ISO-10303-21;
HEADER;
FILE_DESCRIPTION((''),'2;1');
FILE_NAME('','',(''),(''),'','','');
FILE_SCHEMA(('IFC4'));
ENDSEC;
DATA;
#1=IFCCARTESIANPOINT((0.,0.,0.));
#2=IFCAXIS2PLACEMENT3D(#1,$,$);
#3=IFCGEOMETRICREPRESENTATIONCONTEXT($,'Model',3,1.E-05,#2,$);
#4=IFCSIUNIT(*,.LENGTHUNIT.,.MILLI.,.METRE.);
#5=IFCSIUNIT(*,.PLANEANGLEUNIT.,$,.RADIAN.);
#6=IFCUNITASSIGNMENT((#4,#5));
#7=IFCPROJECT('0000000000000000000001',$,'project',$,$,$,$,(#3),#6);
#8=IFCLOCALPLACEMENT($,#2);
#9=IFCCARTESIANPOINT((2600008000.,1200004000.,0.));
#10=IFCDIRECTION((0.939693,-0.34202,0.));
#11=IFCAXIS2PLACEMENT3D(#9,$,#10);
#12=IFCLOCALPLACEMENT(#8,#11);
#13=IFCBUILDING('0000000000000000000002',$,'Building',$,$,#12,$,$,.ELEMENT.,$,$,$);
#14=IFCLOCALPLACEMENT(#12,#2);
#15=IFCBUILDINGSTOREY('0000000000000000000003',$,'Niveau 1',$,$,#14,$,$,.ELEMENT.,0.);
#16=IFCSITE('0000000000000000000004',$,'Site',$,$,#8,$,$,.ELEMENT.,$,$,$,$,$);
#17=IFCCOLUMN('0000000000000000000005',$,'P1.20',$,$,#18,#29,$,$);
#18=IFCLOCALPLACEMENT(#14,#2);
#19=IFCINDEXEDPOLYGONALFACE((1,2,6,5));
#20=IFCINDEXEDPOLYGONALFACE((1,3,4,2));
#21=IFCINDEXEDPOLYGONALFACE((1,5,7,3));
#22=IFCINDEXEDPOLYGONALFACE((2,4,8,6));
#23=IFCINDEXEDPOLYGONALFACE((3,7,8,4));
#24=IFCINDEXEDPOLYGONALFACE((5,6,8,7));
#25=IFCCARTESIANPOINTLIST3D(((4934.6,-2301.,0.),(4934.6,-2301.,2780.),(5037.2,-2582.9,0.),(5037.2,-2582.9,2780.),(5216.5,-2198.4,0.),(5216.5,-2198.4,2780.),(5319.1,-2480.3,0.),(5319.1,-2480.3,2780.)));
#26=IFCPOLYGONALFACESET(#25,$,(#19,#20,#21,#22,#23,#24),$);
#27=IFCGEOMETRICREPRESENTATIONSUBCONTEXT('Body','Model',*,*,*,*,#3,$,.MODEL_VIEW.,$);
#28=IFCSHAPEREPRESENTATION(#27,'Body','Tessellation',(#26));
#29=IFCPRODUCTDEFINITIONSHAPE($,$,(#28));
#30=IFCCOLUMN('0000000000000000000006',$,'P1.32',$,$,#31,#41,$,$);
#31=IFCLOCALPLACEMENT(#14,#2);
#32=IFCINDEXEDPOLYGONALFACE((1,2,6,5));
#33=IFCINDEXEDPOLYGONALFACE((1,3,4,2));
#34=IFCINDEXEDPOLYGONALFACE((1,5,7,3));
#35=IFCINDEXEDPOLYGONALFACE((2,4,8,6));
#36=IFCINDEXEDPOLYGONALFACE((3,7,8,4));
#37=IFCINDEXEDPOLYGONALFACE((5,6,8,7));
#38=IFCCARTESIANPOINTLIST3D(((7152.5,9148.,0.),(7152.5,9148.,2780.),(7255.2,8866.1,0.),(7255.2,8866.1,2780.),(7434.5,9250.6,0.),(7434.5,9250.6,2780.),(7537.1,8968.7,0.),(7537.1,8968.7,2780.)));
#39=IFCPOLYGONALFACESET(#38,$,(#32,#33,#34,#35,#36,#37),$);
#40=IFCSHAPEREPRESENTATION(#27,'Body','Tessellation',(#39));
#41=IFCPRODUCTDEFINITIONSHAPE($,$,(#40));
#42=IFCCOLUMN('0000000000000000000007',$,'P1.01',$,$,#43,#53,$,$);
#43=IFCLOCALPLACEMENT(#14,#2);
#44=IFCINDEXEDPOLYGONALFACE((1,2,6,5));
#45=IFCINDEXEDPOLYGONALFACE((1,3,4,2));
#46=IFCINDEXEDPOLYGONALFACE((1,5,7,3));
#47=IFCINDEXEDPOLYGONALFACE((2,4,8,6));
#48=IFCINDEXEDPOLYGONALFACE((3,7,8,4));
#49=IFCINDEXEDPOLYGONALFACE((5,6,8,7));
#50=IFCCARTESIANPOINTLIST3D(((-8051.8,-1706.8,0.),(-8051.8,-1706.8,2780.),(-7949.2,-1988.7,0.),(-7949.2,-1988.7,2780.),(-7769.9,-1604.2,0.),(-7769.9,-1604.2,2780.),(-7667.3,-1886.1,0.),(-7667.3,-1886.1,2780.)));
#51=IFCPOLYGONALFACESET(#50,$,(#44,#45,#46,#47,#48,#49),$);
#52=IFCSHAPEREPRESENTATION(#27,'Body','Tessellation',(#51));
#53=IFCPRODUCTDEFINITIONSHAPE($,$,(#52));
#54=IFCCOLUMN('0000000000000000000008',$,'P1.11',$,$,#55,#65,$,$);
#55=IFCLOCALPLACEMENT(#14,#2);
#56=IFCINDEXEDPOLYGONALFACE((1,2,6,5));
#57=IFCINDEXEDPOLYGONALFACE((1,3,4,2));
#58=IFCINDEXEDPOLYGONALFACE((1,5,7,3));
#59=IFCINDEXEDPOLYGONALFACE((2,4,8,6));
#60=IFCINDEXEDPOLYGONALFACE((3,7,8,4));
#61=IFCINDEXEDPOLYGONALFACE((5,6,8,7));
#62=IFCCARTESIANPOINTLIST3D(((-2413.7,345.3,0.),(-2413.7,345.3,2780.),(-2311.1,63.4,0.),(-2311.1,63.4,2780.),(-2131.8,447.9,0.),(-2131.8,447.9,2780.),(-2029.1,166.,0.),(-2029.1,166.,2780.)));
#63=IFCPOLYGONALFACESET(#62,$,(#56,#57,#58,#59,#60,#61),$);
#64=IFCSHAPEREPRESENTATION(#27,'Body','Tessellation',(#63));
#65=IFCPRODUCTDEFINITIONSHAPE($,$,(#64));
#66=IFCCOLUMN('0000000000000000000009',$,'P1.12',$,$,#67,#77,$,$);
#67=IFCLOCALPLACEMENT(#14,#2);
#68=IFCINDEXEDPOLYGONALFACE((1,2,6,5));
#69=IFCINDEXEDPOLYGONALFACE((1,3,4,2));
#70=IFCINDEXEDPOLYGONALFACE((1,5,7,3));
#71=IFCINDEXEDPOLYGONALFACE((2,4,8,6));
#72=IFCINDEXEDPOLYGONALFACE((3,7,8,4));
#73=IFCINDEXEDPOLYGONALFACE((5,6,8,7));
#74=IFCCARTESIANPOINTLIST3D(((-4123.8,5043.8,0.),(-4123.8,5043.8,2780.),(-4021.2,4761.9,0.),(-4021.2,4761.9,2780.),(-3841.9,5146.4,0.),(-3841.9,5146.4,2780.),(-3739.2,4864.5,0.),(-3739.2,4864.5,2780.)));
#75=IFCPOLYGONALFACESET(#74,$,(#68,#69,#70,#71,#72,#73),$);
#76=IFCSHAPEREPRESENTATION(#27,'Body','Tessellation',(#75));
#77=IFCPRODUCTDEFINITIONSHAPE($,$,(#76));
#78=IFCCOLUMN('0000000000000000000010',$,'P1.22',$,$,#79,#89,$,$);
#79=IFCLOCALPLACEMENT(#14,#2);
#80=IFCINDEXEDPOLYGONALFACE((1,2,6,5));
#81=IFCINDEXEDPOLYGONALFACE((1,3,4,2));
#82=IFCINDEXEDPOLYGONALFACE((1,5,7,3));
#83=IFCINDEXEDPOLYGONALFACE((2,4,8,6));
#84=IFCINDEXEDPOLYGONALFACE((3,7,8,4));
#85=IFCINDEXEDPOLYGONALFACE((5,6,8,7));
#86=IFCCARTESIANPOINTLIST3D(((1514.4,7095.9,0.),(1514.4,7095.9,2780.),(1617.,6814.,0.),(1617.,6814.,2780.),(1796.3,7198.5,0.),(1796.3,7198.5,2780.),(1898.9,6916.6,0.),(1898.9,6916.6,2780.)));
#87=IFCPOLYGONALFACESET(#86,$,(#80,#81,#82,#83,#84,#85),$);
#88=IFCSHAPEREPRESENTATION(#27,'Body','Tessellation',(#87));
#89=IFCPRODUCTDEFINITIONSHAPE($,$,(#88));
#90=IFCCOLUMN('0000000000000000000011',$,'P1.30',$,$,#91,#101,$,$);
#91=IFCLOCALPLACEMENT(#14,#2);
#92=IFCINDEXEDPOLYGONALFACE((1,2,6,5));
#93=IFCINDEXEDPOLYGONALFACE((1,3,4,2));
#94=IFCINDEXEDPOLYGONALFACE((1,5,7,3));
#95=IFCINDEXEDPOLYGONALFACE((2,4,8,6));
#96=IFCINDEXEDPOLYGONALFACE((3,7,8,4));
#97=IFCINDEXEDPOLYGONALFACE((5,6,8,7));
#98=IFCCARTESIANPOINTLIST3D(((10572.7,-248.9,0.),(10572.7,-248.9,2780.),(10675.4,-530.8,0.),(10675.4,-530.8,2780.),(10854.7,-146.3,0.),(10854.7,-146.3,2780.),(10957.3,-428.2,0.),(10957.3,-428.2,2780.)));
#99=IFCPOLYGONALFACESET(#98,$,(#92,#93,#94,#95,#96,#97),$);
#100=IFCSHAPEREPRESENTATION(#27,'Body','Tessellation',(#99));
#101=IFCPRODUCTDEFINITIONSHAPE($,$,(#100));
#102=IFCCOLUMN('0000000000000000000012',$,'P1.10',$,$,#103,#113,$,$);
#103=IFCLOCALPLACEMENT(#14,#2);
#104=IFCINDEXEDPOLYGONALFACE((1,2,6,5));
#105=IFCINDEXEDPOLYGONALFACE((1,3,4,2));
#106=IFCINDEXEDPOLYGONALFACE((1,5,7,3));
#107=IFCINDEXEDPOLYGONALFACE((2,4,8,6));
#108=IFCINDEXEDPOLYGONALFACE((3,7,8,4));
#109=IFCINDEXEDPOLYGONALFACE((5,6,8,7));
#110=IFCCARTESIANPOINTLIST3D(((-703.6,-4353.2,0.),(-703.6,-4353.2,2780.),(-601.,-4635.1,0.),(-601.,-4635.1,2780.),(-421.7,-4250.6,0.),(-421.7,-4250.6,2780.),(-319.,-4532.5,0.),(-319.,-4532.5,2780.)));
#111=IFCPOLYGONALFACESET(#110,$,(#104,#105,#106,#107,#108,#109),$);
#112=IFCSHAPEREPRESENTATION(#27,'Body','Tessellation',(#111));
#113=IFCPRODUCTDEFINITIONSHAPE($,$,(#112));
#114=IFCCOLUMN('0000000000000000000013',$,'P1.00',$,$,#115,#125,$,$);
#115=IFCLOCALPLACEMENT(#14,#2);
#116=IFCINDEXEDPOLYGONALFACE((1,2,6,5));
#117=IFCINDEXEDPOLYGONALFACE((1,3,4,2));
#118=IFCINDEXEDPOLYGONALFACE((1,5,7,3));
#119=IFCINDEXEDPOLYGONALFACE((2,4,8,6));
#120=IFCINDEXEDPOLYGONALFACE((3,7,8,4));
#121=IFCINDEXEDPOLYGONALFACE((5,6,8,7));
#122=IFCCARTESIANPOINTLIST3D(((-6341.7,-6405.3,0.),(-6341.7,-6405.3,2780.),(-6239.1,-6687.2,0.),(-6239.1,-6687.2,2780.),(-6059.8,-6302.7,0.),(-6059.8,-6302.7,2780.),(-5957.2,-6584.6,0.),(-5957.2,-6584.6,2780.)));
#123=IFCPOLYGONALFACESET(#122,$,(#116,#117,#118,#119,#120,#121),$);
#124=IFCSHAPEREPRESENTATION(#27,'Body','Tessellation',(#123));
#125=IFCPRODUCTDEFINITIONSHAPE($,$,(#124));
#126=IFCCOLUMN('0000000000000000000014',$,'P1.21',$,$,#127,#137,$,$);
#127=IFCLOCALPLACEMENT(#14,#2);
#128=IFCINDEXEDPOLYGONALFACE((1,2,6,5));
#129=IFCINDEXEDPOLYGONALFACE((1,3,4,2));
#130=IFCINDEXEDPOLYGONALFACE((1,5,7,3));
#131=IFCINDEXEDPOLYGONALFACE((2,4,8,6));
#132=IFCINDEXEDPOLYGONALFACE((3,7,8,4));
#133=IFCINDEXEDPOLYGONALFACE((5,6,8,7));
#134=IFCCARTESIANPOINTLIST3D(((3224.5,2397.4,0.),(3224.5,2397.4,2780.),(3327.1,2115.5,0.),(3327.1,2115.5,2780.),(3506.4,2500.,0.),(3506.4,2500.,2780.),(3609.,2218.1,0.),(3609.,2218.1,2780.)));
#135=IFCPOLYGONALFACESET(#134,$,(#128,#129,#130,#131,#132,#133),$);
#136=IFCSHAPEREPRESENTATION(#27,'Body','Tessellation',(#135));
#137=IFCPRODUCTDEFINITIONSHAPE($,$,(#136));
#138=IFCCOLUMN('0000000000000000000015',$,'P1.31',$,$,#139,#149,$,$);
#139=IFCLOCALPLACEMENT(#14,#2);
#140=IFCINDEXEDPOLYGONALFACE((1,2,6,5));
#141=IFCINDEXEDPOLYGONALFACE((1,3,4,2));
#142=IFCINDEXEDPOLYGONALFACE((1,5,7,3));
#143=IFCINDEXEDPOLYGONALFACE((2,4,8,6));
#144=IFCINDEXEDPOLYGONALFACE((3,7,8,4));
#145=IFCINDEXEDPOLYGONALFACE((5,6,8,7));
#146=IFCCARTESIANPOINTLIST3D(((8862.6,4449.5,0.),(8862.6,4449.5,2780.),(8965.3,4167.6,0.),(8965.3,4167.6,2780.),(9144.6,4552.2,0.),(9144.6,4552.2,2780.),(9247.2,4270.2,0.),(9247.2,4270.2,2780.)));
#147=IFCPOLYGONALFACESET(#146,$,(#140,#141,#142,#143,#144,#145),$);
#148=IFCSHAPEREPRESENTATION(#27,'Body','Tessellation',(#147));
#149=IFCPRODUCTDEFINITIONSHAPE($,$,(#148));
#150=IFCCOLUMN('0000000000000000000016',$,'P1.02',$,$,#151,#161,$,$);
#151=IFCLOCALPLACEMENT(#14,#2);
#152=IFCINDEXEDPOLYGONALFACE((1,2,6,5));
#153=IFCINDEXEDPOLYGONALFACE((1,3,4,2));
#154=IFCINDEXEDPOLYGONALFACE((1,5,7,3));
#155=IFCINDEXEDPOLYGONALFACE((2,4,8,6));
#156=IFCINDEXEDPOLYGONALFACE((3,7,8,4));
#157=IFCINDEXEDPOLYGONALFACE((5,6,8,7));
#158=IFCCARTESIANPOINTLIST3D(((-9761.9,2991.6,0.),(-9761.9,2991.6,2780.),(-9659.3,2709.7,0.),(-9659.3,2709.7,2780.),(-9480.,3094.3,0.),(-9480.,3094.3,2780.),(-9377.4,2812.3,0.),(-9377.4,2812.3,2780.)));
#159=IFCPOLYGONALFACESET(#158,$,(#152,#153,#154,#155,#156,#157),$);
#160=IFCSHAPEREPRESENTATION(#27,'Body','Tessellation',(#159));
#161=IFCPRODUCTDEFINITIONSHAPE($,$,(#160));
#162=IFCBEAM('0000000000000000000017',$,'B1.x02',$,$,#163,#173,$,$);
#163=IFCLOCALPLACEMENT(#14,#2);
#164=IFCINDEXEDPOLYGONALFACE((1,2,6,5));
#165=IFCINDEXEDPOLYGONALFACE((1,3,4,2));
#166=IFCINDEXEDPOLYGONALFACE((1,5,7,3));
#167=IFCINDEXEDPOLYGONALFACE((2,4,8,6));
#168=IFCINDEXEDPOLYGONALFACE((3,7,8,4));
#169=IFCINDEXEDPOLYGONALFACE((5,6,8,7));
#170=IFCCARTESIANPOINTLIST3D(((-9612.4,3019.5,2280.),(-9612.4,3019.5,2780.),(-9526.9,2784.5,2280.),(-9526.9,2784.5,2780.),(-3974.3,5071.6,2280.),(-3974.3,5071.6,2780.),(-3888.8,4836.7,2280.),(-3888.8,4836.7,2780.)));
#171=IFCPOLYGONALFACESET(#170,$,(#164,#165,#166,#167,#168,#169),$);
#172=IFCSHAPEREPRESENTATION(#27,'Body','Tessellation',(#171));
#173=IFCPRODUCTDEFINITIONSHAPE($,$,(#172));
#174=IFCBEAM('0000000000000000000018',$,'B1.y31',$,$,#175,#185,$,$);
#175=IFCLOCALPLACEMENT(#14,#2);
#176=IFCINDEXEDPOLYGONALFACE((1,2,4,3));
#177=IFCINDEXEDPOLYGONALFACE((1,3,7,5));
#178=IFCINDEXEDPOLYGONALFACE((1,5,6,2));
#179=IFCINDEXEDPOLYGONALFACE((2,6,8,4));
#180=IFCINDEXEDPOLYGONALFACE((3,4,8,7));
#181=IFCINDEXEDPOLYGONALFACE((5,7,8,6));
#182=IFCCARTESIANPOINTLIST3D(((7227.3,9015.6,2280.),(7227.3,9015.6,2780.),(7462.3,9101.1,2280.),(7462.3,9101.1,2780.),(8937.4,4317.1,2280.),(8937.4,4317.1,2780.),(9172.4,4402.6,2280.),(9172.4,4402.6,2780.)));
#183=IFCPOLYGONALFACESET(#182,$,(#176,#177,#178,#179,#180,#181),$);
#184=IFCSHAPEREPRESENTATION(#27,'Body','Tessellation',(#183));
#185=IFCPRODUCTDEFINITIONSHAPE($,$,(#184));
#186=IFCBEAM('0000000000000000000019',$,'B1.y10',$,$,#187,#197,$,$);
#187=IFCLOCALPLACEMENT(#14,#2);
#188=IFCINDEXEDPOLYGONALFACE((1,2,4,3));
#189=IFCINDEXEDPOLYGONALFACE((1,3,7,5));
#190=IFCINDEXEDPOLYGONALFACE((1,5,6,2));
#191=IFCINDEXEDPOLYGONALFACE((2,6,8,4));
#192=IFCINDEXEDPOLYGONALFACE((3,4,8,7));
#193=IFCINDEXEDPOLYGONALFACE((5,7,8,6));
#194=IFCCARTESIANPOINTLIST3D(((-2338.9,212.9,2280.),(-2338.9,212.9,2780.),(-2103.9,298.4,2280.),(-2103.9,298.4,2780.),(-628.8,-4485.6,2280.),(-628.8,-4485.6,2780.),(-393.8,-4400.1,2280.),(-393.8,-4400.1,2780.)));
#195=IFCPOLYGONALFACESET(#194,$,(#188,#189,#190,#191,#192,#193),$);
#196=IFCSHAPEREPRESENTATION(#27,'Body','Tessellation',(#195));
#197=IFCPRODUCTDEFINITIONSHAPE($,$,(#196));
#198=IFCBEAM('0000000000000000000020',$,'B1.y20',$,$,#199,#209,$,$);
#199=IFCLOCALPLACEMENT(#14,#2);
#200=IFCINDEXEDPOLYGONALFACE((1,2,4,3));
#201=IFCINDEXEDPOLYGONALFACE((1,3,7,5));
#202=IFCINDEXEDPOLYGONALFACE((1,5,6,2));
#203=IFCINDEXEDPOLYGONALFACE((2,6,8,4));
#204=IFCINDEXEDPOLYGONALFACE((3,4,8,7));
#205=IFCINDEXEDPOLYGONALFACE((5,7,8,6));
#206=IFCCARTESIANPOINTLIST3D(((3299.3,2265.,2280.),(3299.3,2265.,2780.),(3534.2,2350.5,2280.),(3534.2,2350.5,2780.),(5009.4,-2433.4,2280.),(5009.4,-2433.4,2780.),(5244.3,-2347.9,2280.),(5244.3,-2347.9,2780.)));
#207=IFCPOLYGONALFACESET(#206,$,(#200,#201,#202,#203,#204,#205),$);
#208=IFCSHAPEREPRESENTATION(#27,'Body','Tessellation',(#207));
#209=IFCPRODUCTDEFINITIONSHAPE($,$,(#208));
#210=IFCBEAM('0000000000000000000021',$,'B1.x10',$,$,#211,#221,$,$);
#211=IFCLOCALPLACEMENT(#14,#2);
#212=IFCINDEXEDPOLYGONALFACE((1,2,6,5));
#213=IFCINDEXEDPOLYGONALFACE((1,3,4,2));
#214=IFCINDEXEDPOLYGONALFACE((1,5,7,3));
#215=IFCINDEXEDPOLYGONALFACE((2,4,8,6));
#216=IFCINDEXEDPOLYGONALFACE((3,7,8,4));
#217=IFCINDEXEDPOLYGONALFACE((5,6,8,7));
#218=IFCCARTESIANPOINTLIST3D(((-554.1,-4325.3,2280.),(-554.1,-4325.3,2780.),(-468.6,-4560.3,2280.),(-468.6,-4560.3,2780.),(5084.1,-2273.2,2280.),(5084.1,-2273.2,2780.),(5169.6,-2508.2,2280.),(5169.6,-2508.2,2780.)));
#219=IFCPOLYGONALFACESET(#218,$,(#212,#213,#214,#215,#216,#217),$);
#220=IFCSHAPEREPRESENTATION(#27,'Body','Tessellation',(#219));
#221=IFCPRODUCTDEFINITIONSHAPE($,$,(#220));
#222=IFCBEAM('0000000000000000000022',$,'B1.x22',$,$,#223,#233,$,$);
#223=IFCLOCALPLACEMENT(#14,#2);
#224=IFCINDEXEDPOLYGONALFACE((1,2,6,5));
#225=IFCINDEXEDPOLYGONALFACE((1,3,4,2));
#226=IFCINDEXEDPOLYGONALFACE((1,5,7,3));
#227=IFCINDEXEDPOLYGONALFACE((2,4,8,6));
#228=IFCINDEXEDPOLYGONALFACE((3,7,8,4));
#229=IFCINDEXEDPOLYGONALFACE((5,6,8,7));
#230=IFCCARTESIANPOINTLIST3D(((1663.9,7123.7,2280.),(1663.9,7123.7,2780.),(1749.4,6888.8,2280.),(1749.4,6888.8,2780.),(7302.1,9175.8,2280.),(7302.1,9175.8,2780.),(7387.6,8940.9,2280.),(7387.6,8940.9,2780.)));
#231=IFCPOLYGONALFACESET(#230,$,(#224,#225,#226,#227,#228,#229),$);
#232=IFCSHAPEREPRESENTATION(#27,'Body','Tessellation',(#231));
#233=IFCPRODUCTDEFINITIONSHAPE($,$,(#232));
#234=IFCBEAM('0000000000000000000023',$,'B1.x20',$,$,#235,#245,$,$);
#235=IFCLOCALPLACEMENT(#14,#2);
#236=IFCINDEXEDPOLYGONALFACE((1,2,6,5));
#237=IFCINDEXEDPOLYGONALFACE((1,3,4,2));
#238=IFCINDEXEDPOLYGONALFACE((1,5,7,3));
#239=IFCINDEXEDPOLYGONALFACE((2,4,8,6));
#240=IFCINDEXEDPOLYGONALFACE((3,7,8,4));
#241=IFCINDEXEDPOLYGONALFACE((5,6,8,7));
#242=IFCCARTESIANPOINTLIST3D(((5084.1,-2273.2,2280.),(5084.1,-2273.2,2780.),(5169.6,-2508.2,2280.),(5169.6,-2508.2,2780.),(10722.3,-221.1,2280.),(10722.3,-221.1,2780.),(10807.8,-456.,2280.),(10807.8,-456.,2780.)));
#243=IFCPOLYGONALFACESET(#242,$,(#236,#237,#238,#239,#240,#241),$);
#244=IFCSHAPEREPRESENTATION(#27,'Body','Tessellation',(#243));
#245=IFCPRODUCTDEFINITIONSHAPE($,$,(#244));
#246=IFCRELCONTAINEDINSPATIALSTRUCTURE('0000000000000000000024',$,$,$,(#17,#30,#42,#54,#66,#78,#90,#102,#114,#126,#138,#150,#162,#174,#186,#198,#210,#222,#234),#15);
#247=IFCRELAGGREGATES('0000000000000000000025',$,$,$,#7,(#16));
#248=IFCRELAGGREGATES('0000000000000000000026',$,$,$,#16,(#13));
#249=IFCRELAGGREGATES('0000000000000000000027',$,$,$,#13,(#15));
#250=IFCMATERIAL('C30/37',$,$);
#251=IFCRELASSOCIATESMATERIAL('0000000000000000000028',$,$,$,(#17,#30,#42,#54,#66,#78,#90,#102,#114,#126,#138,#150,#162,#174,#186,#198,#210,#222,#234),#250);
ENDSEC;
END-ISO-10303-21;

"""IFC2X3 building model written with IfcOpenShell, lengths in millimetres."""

from ifc_helpers import new_model, si_unit, frame, origin, origin_2d, place, context, subcontext, project, spatial, rectangle, extrude, material, element, save


model = new_model("IFC2X3")

# Units and contexts
model_context = context("Model", 3, precision=1e-05, world=origin())
body_context = subcontext(model_context, "Body", "Model", "MODEL_VIEW")
ifc_project = project(units=[si_unit("LENGTHUNIT", "METRE", prefix="MILLI"), si_unit("PLANEANGLEUNIT", "RADIAN")], contexts=[model_context])

# Site, building, storey
site_placement = place(None, origin())
site = spatial("IfcSite", under=ifc_project, at=site_placement, Name="Site", CompositionType="ELEMENT")
building_placement = place(site_placement, frame((2600008000.0, 1200004000.0, 0.0), x_axis=(0.939693, -0.34202, 0.0)))
building = spatial("IfcBuilding", under=site, at=building_placement, Name="Building", CompositionType="ELEMENT")
storey_placement = place(building_placement, origin())
storey = spatial("IfcBuildingStorey", under=building, at=storey_placement, Name="Niveau 1", CompositionType="ELEMENT", Elevation=0.0)

# Columns
ifc_material = material(Name="C30/37")
for number, where, z_axis, x_axis, name in (
    (1, (5126.9, -2390.7, 0.0), (0.0, 0.0, 1.0), (0.939693, 0.34202, 0.0), "P1.20"),
    (2, (7344.8, 9058.4, 0.0), (0.0, 0.0, 1.0), (0.939693, 0.34202, 0.0), "P1.32"),
    (3, (-7859.6, -1796.5, 0.0), (0.0, 0.0, 1.0), (0.939693, 0.34202, 0.0), "P1.01"),
    (4, (-2221.4, 255.7, 0.0), (0.0, 0.0, 1.0), (0.939693, 0.34202, 0.0), "P1.11"),
    (5, (-3931.5, 4954.1, 0.0), (0.0, 0.0, 1.0), (0.939693, 0.34202, 0.0), "P1.12"),
    (6, (1706.6, 7006.2, 0.0), (0.0, 0.0, 1.0), (0.939693, 0.34202, 0.0), "P1.22"),
    (7, (10765.0, -338.6, 0.0), (0.0, 0.0, 1.0), (0.939693, 0.34202, 0.0), "P1.30"),
    (8, (-511.3, -4442.8, 0.0), (0.0, 0.0, 1.0), (0.939693, 0.34202, 0.0), "P1.10"),
    (9, (-6149.5, -6494.9, 0.0), (0.0, 0.0, 1.0), (0.939693, 0.34202, 0.0), "P1.00"),
    (10, (3416.8, 2307.8, 0.0), (0.0, 0.0, 1.0), (0.939693, 0.34202, 0.0), "P1.21"),
    (11, (9054.9, 4359.9, 0.0), (0.0, 0.0, 1.0), (0.939693, 0.34202, 0.0), "P1.31"),
    (12, (-9569.7, 2902.0, 0.0), (0.0, 0.0, 1.0), (0.939693, 0.34202, 0.0), "P1.02"),
):
    element("IfcColumn", number, at=place(storey_placement, frame(where, z_axis=z_axis, x_axis=x_axis)), inside=storey, material=ifc_material, Name=name, context=body_context, shape_type="SweptSolid", body=[
        extrude(rectangle(XDim=300.0, YDim=300.0, at=origin_2d()), origin(), (0.0, 0.0, 1.0), 2780.0),
    ])

# Beams
beam_1_placement = place(storey_placement, frame((-9569.7, 2902.0, 2530.0), z_axis=(0.939693, 0.34202, 0.0), x_axis=(-0.34202, 0.939693, 0.0)))
element("IfcBeam", 13, at=beam_1_placement, inside=storey, material=ifc_material, Name="B1.x02", context=body_context, shape_type="SweptSolid", body=[
    extrude(rectangle(XDim=250.0, YDim=500.0, at=origin_2d()), origin(), (0.0, 0.0, 1.0), 6000.0),
])
for number, where, z_axis, x_axis, name in (
    (14, (9054.9, 4359.9, 2530.0), (-0.34202, 0.939693, 0.0), (-0.939693, -0.34202, 0.0), "B1.y31"),
    (15, (-511.3, -4442.8, 2530.0), (-0.34202, 0.939693, 0.0), (-0.939693, -0.34202, 0.0), "B1.y10"),
    (16, (5126.9, -2390.7, 2530.0), (-0.34202, 0.939693, 0.0), (-0.939693, -0.34202, 0.0), "B1.y20"),
):
    element("IfcBeam", number, at=place(storey_placement, frame(where, z_axis=z_axis, x_axis=x_axis)), inside=storey, material=ifc_material, Name=name, context=body_context, shape_type="SweptSolid", body=[
        extrude(rectangle(XDim=250.0, YDim=500.0, at=origin_2d()), origin(), (0.0, 0.0, 1.0), 5000.0),
    ])
for number, where, z_axis, x_axis, name in (
    (17, (-511.3, -4442.8, 2530.0), (0.939693, 0.34202, 0.0), (-0.34202, 0.939693, 0.0), "B1.x10"),
    (18, (1706.6, 7006.2, 2530.0), (0.939693, 0.34202, 0.0), (-0.34202, 0.939693, 0.0), "B1.x22"),
    (19, (5126.9, -2390.7, 2530.0), (0.939693, 0.34202, 0.0), (-0.34202, 0.939693, 0.0), "B1.x20"),
):
    element("IfcBeam", number, at=place(storey_placement, frame(where, z_axis=z_axis, x_axis=x_axis)), inside=storey, material=ifc_material, Name=name, context=body_context, shape_type="SweptSolid", body=[
        extrude(rectangle(XDim=250.0, YDim=500.0, at=origin_2d()), origin(), (0.0, 0.0, 1.0), 6000.0),
    ])

save(model, "model.ifc")
